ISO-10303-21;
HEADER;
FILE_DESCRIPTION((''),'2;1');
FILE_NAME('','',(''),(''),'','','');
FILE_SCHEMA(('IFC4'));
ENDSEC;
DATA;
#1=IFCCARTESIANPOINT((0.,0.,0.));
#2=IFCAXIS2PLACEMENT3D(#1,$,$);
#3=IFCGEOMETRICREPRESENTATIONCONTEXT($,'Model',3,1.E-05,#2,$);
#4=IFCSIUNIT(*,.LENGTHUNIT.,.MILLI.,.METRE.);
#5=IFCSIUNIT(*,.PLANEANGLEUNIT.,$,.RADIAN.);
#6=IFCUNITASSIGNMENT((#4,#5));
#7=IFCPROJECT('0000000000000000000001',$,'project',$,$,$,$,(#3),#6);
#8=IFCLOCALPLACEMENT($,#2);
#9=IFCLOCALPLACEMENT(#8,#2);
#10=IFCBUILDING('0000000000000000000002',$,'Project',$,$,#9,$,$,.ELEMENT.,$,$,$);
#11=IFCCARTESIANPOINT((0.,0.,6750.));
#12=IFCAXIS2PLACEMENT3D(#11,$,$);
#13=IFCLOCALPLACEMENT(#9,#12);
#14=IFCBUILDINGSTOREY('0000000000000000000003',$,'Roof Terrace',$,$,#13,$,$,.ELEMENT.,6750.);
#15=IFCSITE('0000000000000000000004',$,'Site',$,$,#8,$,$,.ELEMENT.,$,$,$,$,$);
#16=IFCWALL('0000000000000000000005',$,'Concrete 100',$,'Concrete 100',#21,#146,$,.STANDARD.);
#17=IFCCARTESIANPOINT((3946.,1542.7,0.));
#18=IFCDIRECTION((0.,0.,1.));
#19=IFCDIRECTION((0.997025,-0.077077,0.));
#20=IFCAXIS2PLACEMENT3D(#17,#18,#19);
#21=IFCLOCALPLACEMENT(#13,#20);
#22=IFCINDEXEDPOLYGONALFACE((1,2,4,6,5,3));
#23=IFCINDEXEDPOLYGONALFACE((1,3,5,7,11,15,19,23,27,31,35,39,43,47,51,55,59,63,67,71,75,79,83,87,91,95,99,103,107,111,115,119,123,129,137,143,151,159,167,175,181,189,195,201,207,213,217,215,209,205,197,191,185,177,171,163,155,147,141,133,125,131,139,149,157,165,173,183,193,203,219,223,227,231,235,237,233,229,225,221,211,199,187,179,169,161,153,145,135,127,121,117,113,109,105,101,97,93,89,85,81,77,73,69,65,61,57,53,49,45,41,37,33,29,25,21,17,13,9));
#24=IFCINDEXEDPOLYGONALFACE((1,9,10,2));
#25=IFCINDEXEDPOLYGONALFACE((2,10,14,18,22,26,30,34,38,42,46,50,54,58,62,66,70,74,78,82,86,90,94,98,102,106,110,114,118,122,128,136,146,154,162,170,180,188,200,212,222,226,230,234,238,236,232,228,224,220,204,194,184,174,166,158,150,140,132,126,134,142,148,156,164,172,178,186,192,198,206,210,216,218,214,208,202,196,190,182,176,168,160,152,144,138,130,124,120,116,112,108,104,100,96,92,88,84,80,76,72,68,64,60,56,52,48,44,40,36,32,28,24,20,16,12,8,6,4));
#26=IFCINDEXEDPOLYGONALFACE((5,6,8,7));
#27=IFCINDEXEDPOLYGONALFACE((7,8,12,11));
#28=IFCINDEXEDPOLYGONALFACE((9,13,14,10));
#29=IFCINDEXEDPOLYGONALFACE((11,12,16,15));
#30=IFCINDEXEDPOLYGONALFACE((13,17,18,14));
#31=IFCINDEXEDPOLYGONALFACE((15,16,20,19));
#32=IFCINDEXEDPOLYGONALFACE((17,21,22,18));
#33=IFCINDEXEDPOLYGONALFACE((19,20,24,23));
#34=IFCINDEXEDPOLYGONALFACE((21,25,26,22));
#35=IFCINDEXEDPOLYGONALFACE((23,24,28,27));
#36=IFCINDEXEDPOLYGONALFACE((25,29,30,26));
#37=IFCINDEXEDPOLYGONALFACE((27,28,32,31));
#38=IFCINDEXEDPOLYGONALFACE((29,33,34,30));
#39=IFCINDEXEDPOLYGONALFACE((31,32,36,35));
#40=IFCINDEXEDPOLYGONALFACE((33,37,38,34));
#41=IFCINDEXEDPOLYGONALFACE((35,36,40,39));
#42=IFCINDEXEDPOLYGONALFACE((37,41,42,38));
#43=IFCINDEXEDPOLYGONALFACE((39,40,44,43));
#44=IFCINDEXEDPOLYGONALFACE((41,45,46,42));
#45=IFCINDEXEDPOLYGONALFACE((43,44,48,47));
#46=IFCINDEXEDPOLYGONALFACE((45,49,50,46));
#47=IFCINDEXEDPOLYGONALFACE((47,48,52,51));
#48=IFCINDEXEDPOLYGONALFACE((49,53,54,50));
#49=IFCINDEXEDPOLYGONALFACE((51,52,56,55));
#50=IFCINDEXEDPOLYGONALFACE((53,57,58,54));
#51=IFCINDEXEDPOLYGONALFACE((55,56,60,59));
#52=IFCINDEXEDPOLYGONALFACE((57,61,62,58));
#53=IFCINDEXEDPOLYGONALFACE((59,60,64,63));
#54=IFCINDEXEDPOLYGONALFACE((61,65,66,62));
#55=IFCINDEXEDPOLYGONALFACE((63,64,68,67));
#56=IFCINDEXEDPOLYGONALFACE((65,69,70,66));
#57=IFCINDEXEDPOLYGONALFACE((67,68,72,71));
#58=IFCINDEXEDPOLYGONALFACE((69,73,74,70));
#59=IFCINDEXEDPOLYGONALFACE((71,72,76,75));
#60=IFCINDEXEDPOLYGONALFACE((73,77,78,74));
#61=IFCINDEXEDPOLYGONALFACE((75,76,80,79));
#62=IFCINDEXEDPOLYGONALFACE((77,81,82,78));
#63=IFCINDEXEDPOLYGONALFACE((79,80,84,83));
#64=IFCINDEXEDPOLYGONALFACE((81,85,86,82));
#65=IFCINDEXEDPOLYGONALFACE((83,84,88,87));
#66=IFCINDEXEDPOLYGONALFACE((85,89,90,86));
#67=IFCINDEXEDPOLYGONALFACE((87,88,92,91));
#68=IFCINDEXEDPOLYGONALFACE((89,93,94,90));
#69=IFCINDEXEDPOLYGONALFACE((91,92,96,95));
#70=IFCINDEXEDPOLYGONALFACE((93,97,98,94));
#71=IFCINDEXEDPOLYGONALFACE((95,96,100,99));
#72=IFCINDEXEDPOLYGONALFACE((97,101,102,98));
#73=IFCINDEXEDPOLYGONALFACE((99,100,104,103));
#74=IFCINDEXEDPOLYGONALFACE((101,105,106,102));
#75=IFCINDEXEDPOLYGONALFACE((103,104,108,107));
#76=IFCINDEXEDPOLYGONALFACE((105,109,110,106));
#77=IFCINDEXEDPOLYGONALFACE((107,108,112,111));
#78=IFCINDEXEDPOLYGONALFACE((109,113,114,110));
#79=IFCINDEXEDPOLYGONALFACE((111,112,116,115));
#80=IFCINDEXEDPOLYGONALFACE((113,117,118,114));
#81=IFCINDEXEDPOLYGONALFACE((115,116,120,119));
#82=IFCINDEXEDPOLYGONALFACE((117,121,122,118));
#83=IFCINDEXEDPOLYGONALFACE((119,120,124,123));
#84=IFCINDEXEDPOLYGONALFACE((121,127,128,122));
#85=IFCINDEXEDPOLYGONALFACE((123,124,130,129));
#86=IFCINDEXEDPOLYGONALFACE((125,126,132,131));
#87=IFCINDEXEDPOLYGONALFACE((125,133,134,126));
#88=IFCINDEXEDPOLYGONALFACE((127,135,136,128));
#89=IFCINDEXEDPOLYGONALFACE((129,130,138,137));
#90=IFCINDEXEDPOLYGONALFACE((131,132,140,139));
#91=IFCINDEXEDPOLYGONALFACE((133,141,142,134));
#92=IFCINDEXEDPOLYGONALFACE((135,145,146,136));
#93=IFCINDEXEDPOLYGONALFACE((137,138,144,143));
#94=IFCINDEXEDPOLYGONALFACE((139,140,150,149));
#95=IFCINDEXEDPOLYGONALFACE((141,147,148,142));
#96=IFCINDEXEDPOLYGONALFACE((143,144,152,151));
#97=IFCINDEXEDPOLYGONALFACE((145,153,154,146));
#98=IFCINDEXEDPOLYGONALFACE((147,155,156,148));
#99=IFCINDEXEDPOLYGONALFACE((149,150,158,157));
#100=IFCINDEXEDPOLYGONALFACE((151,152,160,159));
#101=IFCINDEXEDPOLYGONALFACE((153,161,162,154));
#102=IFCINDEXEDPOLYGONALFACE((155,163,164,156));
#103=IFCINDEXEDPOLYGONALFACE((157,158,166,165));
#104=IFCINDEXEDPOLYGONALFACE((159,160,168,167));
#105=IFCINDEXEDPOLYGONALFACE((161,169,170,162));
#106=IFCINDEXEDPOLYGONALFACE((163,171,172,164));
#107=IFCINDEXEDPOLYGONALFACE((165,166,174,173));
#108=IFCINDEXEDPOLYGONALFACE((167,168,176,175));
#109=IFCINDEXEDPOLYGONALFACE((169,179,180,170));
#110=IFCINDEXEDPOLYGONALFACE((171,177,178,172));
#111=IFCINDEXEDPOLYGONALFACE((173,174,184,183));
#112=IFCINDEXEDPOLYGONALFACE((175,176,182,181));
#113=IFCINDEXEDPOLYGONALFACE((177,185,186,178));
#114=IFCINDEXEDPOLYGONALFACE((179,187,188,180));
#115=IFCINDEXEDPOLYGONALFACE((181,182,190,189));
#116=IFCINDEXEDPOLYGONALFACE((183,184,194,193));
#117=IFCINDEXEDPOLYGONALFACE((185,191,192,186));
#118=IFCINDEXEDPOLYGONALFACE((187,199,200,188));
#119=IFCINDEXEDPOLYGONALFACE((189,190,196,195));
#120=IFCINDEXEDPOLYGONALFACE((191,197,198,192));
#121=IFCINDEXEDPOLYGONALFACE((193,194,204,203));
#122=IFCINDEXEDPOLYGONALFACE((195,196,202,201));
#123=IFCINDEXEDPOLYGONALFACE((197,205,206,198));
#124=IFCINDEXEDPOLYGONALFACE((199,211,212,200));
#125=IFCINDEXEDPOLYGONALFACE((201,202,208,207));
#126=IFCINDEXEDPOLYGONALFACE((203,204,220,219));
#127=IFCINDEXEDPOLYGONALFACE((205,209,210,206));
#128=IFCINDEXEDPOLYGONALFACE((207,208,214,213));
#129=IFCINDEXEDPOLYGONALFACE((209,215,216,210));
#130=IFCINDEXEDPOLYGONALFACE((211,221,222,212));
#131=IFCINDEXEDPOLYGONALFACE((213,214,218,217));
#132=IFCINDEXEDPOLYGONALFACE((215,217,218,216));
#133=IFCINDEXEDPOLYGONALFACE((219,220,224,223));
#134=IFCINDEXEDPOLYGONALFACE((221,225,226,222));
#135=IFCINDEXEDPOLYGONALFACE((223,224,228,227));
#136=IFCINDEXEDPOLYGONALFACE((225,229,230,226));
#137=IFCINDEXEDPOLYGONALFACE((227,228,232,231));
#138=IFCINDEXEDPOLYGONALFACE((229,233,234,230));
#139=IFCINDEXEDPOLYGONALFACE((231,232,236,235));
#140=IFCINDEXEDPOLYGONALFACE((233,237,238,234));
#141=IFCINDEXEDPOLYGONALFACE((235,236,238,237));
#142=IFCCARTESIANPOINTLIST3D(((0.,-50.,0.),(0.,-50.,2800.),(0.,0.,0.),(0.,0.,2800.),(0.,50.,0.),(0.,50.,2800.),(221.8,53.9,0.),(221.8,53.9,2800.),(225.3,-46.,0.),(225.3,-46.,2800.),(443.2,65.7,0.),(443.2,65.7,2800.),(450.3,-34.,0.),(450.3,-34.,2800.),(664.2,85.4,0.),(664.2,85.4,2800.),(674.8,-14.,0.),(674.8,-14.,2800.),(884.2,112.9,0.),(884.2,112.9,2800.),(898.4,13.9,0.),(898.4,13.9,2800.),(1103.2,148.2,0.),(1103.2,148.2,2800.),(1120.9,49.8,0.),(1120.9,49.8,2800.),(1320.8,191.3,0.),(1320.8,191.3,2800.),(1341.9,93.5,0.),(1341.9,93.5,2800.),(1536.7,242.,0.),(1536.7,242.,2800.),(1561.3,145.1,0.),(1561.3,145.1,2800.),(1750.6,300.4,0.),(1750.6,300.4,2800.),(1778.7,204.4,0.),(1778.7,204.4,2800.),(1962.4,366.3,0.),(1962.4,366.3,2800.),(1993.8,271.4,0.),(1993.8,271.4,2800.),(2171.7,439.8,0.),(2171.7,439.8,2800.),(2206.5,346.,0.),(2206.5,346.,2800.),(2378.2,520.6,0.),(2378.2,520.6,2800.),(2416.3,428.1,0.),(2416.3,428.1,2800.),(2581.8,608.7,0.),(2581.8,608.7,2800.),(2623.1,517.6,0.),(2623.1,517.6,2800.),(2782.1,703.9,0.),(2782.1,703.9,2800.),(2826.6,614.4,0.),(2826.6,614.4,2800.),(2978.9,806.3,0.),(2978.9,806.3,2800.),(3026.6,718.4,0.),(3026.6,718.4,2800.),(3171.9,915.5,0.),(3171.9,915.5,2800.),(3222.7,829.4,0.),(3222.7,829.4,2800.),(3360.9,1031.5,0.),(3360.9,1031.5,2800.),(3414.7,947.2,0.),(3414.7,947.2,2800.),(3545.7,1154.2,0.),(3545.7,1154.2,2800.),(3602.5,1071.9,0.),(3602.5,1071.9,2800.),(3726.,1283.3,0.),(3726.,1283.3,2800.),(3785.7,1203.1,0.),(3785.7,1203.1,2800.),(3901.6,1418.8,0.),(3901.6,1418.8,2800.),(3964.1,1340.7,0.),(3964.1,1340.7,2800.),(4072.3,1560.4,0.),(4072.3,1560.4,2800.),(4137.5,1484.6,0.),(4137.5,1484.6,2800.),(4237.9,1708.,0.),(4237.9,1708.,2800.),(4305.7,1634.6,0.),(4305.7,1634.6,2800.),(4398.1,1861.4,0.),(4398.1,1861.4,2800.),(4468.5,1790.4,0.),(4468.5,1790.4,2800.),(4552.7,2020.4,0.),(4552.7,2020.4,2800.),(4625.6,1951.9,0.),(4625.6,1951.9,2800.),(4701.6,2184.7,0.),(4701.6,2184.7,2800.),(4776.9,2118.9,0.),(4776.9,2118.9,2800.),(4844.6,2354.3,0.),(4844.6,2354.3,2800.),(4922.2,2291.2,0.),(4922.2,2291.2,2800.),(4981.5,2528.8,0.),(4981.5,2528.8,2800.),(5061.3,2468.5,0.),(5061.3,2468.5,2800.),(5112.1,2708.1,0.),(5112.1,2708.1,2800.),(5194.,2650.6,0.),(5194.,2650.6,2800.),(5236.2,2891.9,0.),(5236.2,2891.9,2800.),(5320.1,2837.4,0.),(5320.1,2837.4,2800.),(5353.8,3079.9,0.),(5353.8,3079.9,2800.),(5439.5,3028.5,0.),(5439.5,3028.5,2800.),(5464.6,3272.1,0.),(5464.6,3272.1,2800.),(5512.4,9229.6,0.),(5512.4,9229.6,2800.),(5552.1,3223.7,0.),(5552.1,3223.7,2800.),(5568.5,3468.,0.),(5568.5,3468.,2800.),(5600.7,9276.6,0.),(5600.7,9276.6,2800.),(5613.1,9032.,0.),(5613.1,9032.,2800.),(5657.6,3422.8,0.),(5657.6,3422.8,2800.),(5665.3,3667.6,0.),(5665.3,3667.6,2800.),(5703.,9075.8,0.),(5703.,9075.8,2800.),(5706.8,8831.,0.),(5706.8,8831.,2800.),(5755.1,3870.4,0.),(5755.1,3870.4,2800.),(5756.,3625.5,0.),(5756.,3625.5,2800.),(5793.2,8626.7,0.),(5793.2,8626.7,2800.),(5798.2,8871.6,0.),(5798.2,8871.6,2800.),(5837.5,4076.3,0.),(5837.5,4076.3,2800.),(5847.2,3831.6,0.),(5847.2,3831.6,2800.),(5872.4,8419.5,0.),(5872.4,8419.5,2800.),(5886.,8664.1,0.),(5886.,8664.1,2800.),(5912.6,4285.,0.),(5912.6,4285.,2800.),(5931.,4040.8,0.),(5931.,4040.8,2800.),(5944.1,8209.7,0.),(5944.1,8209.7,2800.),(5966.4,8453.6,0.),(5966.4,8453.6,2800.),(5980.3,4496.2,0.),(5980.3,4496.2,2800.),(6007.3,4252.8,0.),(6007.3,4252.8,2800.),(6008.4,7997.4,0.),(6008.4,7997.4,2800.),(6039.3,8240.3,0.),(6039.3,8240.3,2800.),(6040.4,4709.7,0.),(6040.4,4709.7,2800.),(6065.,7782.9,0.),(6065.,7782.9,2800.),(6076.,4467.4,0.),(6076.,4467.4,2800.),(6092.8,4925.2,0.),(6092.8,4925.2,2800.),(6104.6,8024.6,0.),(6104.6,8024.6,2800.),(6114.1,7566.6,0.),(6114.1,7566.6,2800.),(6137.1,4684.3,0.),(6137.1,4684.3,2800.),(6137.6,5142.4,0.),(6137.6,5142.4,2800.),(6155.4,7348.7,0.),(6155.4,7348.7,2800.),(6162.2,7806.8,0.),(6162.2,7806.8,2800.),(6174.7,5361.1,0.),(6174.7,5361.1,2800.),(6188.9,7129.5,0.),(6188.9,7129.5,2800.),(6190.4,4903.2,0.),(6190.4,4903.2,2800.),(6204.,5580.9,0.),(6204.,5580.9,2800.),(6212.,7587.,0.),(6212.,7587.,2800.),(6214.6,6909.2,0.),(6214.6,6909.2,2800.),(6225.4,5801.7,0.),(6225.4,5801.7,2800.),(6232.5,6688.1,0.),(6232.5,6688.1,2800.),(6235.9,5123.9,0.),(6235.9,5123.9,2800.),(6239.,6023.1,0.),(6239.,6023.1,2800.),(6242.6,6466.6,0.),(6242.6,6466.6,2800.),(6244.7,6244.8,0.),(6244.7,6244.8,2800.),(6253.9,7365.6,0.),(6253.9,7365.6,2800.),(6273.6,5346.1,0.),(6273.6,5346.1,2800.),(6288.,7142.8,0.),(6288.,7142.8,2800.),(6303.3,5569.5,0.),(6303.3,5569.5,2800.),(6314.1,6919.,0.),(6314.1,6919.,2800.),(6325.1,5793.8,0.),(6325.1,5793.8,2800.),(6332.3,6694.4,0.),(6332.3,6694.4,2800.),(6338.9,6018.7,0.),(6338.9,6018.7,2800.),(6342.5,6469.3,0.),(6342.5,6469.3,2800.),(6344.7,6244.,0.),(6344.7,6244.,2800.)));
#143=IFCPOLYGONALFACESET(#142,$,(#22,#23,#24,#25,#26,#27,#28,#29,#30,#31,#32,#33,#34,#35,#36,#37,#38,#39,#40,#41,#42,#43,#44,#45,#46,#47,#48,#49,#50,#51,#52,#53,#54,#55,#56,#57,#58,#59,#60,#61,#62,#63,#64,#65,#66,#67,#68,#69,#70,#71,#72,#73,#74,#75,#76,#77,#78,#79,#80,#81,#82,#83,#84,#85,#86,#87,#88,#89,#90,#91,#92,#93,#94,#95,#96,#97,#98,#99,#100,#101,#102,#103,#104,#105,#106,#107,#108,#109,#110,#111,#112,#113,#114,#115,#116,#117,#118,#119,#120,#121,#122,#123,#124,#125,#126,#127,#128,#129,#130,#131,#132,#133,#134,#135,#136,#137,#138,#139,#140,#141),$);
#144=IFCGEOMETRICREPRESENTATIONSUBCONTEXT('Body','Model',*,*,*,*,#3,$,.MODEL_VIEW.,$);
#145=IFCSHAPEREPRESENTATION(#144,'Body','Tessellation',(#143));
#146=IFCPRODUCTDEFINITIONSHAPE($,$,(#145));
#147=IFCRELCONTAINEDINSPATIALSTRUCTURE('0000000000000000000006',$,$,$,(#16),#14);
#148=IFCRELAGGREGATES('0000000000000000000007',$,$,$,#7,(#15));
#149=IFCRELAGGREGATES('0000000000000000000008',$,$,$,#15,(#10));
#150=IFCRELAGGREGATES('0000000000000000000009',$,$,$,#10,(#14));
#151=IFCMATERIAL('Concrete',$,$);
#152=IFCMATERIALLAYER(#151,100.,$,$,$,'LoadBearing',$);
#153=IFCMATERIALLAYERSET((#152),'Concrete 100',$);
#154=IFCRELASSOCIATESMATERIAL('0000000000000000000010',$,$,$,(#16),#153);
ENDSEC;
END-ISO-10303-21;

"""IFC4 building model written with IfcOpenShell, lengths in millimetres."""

from ifc_helpers import new_model, si_unit, frame, origin, place, context, subcontext, project, spatial, polyline, outline, extrude, material, layer, layer_set, layer_usage, element, save


model = new_model("IFC4")

# Units and contexts
model_context = context("Model", 3, precision=1e-05, world=origin())
body_context = subcontext(model_context, "Body", "Model", "MODEL_VIEW")
ifc_project = project(units=[si_unit("LENGTHUNIT", "METRE", prefix="MILLI"), si_unit("PLANEANGLEUNIT", "RADIAN")], contexts=[model_context])

# Site, building, storey
site_placement = place(None, origin())
site = spatial("IfcSite", under=ifc_project, at=site_placement, Name="Site", CompositionType="ELEMENT")
building_placement = place(site_placement, origin())
building = spatial("IfcBuilding", under=site, at=building_placement, Name="Project", CompositionType="ELEMENT")
storey_placement = place(building_placement, frame((0.0, 0.0, 6750.0)))
storey = spatial("IfcBuildingStorey", under=building, at=storey_placement, Name="Roof Terrace", CompositionType="ELEMENT", Elevation=6750.0)

# Shared definitions
ifc_material = material(Name="Concrete")

# Wall
ifc_layer_1 = layer(ifc_material, 100.0, Category="LoadBearing")
ifc_layer_set_1 = layer_set([ifc_layer_1], Name="Concrete 100")
ifc_layer_usage_1 = layer_usage(ifc_layer_set_1, "AXIS2", "NEGATIVE", 50.0)
wall_1_placement = place(storey_placement, frame((3946.0, 1542.7, 0.0), z_axis=(0.0, 0.0, 1.0), x_axis=(0.997025, -0.077077, 0.0)))
element("IfcWall", 1, at=wall_1_placement, inside=storey, material=ifc_layer_usage_1, Name="Concrete 100", ObjectType="Concrete 100", PredefinedType="STANDARD", context=body_context, shape_type="SweptSolid", body=[
    extrude(outline(polyline([(0.0, -50.0), (0.0, 0.0), (0.0, 50.0), (221.8, 53.9), (443.2, 65.7), (664.2, 85.4), (884.2, 112.9), (1103.2, 148.2), (1320.8, 191.3), (1536.7, 242.0), (1750.6, 300.4), (1962.4, 366.3), (2171.7, 439.8), (2378.2, 520.6), (2581.8, 608.7), (2782.1, 703.9), (2978.9, 806.3), (3171.9, 915.5), (3360.9, 1031.5), (3545.7, 1154.2), (3726.0, 1283.3), (3901.6, 1418.8), (4072.3, 1560.4), (4237.9, 1708.0), (4398.1, 1861.4), (4552.7, 2020.4), (4701.6, 2184.7), (4844.6, 2354.3), (4981.5, 2528.8), (5112.1, 2708.1), (5236.2, 2891.9), (5353.8, 3079.9), (5464.6, 3272.1), (5568.5, 3468.0), (5665.3, 3667.6), (5755.1, 3870.4), (5837.5, 4076.3), (5912.6, 4285.0), (5980.3, 4496.2), (6040.4, 4709.7), (6092.8, 4925.2), (6137.6, 5142.4), (6174.7, 5361.1), (6204.0, 5580.9), (6225.4, 5801.7), (6239.0, 6023.1), (6244.7, 6244.8), (6242.6, 6466.6), (6232.5, 6688.1), (6214.6, 6909.2), (6188.9, 7129.5), (6155.4, 7348.7), (6114.1, 7566.6), (6065.0, 7782.9), (6008.4, 7997.4), (5944.1, 8209.7), (5872.4, 8419.5), (5793.2, 8626.7), (5706.8, 8831.0), (5613.1, 9032.0), (5512.4, 9229.6), (5600.7, 9276.6), (5703.0, 9075.8), (5798.2, 8871.6), (5886.0, 8664.1), (5966.4, 8453.6), (6039.3, 8240.3), (6104.6, 8024.6), (6162.2, 7806.8), (6212.0, 7587.0), (6253.9, 7365.6), (6288.0, 7142.8), (6314.1, 6919.0), (6332.3, 6694.4), (6342.5, 6469.3), (6344.7, 6244.0), (6338.9, 6018.7), (6325.1, 5793.8), (6303.3, 5569.5), (6273.6, 5346.1), (6235.9, 5123.9), (6190.4, 4903.2), (6137.1, 4684.3), (6076.0, 4467.4), (6007.3, 4252.8), (5931.0, 4040.8), (5847.2, 3831.6), (5756.0, 3625.5), (5657.6, 3422.8), (5552.1, 3223.7), (5439.5, 3028.5), (5320.1, 2837.4), (5194.0, 2650.6), (5061.3, 2468.5), (4922.2, 2291.2), (4776.9, 2118.9), (4625.6, 1951.9), (4468.5, 1790.4), (4305.7, 1634.6), (4137.5, 1484.6), (3964.1, 1340.7), (3785.7, 1203.1), (3602.5, 1071.9), (3414.7, 947.2), (3222.7, 829.4), (3026.6, 718.4), (2826.6, 614.4), (2623.1, 517.6), (2416.3, 428.1), (2206.5, 346.0), (1993.8, 271.4), (1778.7, 204.4), (1561.3, 145.1), (1341.9, 93.5), (1120.9, 49.8), (898.4, 13.9), (674.8, -14.0), (450.3, -34.0), (225.3, -46.0), (0.0, -50.0)])), origin(), (0.0, 0.0, 1.0), 2800.0),
])

save(model, "model.ifc")
